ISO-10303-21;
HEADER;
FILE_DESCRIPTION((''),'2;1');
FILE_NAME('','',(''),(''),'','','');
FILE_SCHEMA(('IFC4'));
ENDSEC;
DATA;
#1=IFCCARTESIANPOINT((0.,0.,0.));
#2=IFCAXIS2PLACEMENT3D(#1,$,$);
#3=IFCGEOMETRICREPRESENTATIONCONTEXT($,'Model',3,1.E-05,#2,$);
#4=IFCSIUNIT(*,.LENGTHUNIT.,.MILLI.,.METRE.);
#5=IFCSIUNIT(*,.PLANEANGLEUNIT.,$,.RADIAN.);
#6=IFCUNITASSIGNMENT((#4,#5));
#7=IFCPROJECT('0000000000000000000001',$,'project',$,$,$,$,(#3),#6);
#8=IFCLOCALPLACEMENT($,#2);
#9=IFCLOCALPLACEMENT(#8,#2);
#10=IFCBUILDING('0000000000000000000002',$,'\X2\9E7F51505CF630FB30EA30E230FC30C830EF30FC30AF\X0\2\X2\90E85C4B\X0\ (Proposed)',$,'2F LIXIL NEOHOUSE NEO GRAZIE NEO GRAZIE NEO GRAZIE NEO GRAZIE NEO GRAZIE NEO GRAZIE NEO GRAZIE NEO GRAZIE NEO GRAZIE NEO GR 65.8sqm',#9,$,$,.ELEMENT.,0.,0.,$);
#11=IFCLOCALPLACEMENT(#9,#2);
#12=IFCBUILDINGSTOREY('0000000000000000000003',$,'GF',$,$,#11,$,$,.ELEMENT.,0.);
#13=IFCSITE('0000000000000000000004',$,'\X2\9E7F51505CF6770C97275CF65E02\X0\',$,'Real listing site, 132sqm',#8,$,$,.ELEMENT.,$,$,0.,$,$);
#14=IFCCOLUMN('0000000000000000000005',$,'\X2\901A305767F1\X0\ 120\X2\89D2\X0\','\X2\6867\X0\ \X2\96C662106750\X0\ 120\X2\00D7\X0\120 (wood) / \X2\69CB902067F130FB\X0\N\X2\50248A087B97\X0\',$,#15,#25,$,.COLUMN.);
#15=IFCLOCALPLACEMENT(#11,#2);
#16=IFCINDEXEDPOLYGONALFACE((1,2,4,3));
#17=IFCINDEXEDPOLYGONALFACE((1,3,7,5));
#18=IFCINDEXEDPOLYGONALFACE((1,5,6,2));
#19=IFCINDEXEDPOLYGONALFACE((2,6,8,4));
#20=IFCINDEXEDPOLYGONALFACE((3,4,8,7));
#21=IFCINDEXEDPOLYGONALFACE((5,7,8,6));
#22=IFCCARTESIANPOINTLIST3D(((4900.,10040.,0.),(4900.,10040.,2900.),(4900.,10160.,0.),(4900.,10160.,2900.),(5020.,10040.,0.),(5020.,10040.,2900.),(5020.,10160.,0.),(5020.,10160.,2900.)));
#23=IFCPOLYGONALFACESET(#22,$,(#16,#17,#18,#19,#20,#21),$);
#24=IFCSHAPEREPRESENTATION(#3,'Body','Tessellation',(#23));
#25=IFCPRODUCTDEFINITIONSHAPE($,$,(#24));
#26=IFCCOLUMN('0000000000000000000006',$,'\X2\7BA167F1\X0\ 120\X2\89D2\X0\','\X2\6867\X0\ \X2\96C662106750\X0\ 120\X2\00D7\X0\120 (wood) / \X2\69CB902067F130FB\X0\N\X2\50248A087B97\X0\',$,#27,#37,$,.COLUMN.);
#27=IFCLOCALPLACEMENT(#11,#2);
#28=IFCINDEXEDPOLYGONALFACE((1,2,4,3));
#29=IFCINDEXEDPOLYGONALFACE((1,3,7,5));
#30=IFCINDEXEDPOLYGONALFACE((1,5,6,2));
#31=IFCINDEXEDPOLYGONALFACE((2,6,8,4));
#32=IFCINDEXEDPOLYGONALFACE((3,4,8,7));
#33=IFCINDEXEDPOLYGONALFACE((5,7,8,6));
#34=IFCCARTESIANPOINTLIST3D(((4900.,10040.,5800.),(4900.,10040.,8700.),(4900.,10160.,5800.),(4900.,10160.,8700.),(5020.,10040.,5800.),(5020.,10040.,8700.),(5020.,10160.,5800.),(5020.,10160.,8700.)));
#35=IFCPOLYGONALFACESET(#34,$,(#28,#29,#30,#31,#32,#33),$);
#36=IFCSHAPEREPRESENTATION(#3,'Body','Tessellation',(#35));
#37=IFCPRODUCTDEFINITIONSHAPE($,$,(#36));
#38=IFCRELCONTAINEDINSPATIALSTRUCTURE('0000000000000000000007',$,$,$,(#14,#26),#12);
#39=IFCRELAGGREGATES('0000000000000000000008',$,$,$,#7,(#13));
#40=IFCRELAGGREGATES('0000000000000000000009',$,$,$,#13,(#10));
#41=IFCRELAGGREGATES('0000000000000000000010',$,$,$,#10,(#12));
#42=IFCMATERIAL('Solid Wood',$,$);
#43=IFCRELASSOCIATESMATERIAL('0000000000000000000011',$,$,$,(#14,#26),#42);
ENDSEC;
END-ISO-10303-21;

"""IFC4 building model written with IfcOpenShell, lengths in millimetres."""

from ifc_helpers import new_model, si_unit, frame, frame_2d, origin, place, context, project, spatial, rectangle, extrude, material, element, save


model = new_model("IFC4")

# Units and contexts
model_context = context("Model", 3, precision=1e-05, world=origin())
ifc_project = project(units=[si_unit("LENGTHUNIT", "METRE", prefix="MILLI"), si_unit("PLANEANGLEUNIT", "RADIAN")], contexts=[model_context])

# Site, building, storey
site_placement = place(None, origin())
site = spatial("IfcSite", under=ifc_project, at=site_placement, Name="鹿児島県霧島市", ObjectType="Real listing site, 132sqm", CompositionType="ELEMENT", RefElevation=0.0)
building_placement = place(site_placement, origin())
building = spatial("IfcBuilding", under=site, at=building_placement, Name="鹿児島・リモートワーク2部屋 (Proposed)", ObjectType="2F LIXIL NEOHOUSE NEO GRAZIE NEO GRAZIE NEO GRAZIE NEO GRAZIE NEO GRAZIE NEO GRAZIE NEO GRAZIE NEO GRAZIE NEO GRAZIE NEO GR 65.8sqm", CompositionType="ELEMENT", ElevationOfRefHeight=0.0, ElevationOfTerrain=0.0)
storey_placement = place(building_placement, origin())
storey = spatial("IfcBuildingStorey", under=building, at=storey_placement, Name="GF", CompositionType="ELEMENT", Elevation=0.0)

# Columns
ifc_material_1 = material(Name="Solid Wood")
column_1_placement = place(storey_placement, frame((2450.0, 5020.0, 0.0)))
element("IfcColumn", 1, at=column_1_placement, inside=storey, material=ifc_material_1, Name="通し柱 120角", Description="桧 集成材 120×120 (wood) / 構造柱・N値計算", PredefinedType="COLUMN", context=model_context, shape_type="SweptSolid", body=[
    extrude(rectangle(XDim=120.0, YDim=120.0, at=frame_2d((60.0, 60.0))), frame((2450.0, 5020.0, 0.0)), (0.0, 0.0, 1.0), 2900.0),
])
column_2_placement = place(storey_placement, frame((2450.0, 5020.0, 2900.0)))
element("IfcColumn", 2, at=column_2_placement, inside=storey, material=ifc_material_1, Name="管柱 120角", Description="桧 集成材 120×120 (wood) / 構造柱・N値計算", PredefinedType="COLUMN", context=model_context, shape_type="SweptSolid", body=[
    extrude(rectangle(XDim=120.0, YDim=120.0, at=frame_2d((60.0, 60.0))), frame((2450.0, 5020.0, 2900.0)), (0.0, 0.0, 1.0), 2900.0),
])

save(model, "model.ifc")
